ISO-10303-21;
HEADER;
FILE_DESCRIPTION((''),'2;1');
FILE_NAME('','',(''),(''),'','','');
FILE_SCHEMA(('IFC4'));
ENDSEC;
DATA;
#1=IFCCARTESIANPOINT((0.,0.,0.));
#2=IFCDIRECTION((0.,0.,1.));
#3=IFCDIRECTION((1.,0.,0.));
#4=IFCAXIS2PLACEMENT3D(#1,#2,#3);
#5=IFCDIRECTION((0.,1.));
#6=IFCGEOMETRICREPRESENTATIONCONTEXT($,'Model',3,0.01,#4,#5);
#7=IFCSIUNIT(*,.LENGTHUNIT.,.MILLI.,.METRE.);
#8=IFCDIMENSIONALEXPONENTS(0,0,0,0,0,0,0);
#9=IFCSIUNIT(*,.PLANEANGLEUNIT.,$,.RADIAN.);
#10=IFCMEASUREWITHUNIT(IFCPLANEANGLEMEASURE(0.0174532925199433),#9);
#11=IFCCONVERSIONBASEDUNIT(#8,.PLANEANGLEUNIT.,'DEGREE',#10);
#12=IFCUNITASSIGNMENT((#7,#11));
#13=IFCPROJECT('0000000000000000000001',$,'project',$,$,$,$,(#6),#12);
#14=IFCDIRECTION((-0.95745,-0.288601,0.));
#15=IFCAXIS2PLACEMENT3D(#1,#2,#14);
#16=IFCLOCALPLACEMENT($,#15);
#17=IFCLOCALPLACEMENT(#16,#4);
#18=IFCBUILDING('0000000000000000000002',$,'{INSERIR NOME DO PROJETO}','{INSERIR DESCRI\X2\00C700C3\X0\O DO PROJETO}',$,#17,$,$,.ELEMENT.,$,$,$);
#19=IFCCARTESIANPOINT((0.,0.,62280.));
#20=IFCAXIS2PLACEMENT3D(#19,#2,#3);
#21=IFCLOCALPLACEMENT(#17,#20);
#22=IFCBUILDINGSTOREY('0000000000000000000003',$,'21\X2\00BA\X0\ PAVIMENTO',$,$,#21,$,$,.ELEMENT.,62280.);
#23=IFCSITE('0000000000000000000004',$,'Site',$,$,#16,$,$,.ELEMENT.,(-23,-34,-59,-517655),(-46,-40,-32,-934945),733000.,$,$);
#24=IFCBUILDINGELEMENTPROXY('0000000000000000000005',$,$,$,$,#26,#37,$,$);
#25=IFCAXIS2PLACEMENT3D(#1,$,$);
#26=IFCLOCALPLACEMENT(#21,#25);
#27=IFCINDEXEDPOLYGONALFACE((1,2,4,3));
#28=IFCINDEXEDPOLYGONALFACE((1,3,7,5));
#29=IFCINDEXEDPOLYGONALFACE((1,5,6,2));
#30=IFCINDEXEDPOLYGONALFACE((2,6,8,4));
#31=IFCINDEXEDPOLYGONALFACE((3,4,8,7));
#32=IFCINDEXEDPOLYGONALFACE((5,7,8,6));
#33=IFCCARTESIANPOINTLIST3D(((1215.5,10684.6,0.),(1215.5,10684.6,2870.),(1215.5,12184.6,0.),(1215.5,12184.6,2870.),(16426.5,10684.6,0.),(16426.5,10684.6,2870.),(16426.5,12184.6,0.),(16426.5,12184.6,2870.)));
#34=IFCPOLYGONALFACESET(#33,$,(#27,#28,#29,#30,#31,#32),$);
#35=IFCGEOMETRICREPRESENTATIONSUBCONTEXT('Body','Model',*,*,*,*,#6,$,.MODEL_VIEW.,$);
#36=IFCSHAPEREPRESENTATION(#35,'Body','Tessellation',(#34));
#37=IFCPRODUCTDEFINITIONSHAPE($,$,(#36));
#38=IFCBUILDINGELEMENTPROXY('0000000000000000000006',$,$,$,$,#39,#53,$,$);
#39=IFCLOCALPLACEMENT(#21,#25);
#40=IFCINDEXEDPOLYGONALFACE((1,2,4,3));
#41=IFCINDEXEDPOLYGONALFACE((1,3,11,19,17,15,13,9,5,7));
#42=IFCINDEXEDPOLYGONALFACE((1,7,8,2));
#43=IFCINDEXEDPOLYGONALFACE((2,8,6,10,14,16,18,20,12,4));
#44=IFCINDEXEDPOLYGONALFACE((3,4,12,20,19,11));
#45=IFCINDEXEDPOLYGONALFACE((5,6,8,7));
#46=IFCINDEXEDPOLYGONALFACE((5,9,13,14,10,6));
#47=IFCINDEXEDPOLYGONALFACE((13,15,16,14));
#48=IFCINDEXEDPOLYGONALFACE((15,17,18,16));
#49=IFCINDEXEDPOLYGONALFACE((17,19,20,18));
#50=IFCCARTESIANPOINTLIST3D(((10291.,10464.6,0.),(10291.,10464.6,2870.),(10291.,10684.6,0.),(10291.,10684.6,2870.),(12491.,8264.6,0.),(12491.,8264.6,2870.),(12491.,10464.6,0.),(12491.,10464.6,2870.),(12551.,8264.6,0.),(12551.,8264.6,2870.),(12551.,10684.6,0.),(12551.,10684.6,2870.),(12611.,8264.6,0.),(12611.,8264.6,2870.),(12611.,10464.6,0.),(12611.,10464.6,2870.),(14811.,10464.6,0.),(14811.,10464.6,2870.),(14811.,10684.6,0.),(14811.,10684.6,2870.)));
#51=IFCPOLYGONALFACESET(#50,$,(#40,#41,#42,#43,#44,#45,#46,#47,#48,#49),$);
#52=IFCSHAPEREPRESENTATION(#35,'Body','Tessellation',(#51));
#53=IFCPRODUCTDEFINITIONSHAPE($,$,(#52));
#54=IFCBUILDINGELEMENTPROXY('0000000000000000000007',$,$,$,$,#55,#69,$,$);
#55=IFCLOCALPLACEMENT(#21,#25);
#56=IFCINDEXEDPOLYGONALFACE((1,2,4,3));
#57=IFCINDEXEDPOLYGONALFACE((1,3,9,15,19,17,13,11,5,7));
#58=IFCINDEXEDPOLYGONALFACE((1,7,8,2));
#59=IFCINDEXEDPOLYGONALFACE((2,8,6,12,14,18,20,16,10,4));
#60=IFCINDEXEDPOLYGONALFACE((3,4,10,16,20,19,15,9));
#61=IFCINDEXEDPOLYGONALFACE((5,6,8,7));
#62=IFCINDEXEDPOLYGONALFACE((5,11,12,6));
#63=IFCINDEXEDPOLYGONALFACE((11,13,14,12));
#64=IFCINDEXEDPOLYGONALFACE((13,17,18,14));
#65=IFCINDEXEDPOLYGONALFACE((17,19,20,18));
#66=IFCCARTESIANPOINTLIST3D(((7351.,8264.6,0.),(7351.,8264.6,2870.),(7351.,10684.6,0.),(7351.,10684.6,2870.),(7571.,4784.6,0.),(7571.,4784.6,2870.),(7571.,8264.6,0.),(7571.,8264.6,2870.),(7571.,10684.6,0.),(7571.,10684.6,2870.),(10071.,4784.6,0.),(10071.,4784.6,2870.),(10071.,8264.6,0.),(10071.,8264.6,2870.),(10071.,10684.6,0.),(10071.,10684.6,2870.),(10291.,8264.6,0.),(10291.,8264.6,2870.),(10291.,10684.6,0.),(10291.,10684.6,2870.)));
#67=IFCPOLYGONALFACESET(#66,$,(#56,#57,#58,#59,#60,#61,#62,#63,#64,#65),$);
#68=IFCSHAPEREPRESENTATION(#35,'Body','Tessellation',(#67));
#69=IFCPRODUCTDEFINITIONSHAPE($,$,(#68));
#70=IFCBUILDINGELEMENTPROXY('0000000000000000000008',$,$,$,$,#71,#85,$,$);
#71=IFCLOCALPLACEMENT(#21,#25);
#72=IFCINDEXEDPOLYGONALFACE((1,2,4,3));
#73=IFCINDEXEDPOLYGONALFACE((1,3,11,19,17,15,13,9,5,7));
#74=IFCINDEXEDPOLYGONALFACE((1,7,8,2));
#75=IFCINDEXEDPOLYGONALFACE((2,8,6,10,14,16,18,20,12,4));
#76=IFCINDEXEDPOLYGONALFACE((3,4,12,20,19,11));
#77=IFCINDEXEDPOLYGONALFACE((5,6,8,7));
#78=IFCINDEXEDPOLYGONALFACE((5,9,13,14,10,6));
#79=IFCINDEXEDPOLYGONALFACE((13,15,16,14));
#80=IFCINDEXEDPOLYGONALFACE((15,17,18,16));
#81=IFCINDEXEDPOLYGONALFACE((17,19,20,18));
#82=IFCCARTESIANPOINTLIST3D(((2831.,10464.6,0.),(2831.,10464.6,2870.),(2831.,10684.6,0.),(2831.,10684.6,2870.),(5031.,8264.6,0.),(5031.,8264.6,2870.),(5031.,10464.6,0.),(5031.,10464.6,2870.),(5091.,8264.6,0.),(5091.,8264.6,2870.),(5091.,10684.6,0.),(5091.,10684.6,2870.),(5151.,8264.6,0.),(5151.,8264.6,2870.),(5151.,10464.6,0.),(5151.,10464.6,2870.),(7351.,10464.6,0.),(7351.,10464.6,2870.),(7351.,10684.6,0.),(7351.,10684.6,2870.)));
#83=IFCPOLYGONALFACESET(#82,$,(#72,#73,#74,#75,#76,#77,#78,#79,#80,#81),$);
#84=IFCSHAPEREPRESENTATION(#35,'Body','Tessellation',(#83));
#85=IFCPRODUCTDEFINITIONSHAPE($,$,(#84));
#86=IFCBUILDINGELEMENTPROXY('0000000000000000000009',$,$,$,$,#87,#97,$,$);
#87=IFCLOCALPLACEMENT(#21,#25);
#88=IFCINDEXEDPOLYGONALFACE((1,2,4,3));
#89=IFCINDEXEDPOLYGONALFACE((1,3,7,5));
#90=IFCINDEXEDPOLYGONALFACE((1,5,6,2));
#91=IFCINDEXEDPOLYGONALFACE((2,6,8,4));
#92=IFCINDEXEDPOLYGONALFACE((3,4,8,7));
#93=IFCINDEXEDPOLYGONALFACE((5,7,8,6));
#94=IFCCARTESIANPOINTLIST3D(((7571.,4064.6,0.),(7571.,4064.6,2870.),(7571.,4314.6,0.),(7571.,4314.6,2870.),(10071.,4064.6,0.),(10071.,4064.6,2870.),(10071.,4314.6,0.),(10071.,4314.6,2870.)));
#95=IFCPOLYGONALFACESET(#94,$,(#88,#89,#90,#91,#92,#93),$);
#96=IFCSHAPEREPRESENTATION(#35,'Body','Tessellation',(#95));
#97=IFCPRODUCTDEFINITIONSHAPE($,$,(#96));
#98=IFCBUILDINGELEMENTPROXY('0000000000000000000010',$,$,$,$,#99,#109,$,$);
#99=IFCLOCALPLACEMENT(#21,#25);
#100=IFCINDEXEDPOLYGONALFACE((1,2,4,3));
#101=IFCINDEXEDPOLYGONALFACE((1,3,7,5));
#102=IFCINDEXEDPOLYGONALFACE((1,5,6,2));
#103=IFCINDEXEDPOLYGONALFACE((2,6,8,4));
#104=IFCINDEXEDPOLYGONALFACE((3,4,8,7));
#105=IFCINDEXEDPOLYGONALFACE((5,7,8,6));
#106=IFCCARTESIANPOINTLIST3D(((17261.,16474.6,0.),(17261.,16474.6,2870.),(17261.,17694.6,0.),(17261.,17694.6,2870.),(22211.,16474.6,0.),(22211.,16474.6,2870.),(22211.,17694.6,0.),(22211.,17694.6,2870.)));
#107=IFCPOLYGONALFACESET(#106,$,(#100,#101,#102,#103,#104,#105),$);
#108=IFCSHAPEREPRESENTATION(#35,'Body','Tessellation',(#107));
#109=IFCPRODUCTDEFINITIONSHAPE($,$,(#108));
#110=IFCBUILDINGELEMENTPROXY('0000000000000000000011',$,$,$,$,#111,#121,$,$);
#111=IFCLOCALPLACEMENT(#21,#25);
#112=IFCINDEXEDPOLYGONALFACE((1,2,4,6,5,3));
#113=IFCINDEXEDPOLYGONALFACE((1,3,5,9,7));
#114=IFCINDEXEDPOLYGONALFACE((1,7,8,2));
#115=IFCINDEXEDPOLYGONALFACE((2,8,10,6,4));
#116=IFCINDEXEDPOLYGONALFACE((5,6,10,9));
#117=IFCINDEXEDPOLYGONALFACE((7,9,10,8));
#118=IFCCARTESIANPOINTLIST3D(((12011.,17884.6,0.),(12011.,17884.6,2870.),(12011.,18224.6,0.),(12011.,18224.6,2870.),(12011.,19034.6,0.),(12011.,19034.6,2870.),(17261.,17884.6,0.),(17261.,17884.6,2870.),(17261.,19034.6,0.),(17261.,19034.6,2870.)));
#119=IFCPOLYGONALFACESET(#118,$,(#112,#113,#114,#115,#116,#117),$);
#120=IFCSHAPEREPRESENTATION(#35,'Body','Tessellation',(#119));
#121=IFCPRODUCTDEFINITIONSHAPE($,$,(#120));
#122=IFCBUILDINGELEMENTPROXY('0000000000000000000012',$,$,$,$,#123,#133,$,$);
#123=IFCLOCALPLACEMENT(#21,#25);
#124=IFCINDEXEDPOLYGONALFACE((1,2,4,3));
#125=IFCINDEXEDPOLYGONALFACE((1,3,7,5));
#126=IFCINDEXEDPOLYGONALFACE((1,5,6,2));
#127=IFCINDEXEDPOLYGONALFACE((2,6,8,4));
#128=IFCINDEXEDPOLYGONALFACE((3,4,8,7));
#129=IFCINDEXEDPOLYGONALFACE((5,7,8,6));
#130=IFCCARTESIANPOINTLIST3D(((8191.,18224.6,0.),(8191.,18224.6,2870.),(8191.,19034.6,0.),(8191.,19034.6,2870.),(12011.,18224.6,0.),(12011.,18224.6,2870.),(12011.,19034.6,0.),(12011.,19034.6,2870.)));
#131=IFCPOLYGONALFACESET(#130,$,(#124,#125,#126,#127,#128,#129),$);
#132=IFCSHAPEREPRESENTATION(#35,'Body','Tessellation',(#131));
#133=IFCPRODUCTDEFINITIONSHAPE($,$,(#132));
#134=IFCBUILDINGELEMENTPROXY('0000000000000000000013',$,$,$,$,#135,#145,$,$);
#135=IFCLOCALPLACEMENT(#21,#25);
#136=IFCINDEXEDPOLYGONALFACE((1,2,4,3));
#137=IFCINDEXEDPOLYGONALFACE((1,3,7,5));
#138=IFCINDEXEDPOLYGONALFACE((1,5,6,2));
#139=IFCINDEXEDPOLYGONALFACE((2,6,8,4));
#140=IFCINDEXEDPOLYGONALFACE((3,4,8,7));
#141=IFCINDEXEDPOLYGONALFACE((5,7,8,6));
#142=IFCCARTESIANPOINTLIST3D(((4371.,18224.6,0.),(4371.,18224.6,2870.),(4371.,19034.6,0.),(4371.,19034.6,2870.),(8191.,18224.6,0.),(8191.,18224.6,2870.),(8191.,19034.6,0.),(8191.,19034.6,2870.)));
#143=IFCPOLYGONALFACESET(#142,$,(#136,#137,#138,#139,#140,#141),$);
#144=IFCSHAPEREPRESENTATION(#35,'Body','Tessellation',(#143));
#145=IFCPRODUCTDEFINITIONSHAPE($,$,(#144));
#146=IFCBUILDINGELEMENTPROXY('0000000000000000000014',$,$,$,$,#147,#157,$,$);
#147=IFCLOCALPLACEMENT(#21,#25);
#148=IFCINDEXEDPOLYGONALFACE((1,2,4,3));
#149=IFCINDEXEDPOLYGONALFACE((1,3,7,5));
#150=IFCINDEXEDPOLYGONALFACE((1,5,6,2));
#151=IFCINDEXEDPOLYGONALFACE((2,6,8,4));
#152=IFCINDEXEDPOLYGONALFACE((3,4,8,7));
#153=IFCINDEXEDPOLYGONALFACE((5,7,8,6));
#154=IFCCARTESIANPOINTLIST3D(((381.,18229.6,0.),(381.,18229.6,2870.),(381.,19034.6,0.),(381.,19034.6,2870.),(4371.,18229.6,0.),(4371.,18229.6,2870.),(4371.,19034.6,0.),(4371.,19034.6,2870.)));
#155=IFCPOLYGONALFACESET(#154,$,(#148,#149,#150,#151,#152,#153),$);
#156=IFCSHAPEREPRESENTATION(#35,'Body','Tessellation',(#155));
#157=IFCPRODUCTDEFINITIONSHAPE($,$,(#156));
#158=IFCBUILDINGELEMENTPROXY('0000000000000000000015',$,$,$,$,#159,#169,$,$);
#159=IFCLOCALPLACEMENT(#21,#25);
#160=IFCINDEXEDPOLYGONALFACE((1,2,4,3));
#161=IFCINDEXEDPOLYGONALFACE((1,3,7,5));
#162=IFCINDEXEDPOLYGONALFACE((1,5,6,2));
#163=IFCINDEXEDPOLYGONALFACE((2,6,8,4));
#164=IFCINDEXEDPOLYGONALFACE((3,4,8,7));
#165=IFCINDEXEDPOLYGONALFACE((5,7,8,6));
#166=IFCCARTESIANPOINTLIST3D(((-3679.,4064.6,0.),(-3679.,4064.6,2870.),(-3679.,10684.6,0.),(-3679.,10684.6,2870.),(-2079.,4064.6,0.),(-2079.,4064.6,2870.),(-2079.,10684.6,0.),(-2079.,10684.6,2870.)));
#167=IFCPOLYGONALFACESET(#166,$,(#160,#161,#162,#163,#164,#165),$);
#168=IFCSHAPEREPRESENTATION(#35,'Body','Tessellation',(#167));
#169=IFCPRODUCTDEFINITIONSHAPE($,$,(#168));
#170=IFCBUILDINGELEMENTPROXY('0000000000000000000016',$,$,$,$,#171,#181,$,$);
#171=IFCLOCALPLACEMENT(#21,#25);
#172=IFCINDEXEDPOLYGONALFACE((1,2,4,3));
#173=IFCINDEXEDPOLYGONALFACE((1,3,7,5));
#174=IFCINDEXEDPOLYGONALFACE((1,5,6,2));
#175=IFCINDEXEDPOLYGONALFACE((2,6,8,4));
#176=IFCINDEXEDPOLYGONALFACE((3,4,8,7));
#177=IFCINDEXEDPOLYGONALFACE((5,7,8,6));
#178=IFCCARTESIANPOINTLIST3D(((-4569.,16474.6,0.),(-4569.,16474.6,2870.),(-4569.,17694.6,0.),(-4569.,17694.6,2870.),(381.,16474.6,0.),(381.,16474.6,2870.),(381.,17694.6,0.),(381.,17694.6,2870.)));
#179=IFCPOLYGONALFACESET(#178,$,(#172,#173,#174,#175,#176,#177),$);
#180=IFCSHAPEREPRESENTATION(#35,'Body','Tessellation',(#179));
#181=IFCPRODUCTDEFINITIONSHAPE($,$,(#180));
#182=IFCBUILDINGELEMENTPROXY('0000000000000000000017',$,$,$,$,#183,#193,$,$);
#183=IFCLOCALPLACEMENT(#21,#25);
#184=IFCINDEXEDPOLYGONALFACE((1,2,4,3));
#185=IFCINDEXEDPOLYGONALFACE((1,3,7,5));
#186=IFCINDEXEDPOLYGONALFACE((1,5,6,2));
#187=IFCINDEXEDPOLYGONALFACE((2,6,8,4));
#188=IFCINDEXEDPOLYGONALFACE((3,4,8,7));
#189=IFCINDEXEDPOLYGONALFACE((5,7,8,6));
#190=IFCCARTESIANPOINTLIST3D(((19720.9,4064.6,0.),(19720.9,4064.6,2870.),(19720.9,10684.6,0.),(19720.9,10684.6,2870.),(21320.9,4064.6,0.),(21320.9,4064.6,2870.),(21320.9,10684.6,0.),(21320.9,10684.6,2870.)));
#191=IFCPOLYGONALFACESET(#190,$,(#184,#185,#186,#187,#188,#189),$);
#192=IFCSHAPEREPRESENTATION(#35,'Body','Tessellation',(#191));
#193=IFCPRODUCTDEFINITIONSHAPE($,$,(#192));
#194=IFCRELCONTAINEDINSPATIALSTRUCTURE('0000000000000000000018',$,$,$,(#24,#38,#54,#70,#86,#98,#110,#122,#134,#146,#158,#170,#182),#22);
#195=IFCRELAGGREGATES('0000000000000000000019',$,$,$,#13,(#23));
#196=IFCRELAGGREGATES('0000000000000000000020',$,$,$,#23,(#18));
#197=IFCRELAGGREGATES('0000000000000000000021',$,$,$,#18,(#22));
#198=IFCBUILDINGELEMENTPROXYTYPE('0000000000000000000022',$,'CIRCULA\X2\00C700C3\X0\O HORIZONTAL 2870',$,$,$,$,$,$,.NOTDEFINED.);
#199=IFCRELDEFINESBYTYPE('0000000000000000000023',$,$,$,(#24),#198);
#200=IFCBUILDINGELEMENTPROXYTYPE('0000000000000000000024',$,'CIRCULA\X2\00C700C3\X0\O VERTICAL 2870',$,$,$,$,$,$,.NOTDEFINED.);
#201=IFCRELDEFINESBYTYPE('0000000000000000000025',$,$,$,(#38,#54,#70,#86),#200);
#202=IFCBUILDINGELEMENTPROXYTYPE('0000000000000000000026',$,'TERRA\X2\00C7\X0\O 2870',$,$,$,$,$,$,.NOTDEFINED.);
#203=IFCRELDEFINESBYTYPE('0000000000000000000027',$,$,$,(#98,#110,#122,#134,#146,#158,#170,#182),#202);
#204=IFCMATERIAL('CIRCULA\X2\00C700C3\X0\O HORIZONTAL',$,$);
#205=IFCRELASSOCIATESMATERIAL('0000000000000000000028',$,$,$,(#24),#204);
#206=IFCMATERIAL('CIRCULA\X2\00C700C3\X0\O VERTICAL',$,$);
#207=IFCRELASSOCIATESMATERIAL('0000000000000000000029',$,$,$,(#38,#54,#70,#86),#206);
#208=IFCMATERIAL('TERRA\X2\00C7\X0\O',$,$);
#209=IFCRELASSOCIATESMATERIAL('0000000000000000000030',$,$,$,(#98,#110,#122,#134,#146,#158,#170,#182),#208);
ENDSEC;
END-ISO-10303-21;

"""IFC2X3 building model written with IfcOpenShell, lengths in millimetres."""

from ifc_helpers import new_model, entity, si_unit, converted_unit, direction, frame, origin_with_axes, place, context, subcontext, project, spatial, polyline, outline, extrude, material, type_object, element, save


model = new_model("IFC2X3")

# Units and contexts
model_context = context("Model", 3, precision=0.01, world=origin_with_axes(), true_north=direction((0.0, 1.0)))
body_context = subcontext(model_context, "Body", "Model", "MODEL_VIEW")
ifc_project = project(units=[si_unit("LENGTHUNIT", "METRE", prefix="MILLI"), converted_unit("PLANEANGLEUNIT", "DEGREE", entity("IfcPlaneAngleMeasure", 0.0174532925199433), si_unit("PLANEANGLEUNIT", "RADIAN"), dimensions=[0, 0, 0, 0, 0, 0, 0])], contexts=[model_context])

# Site, building, storey
site_placement = place(None, frame((0.0, 0.0, 0.0), z_axis=(0.0, 0.0, 1.0), x_axis=(-0.95745, -0.288601, 0.0)))
site = spatial("IfcSite", under=ifc_project, at=site_placement, Name="Site", CompositionType="ELEMENT", RefLatitude=(-23, -34, -59, -517655), RefLongitude=(-46, -40, -32, -934945), RefElevation=733000.0)
building_placement = place(site_placement, origin_with_axes())
building = spatial("IfcBuilding", under=site, at=building_placement, Name="{INSERIR NOME DO PROJETO}", Description="{INSERIR DESCRIÇÃO DO PROJETO}", CompositionType="ELEMENT")
storey_placement = place(building_placement, frame((0.0, 0.0, 62280.0), z_axis=(0.0, 0.0, 1.0), x_axis=(1.0, 0.0, 0.0)))
storey = spatial("IfcBuildingStorey", under=building, at=storey_placement, Name="21º PAVIMENTO", CompositionType="ELEMENT", Elevation=62280.0)

# Building element proxies
ifc_material_1 = material(Name="CIRCULAÇÃO HORIZONTAL")
building_element_proxy_type_1 = type_object("IfcBuildingElementProxyType", Name="CIRCULAÇÃO HORIZONTAL 2870", PredefinedType="NOTDEFINED")
proxy_1_placement = place(storey_placement, frame((1215.5, 10684.6, 0.0), z_axis=(0.0, 0.0, 1.0), x_axis=(1.0, 0.0, 0.0)))
element("IfcBuildingElementProxy", 1, at=proxy_1_placement, inside=storey, type_object=building_element_proxy_type_1, material=ifc_material_1, context=body_context, shape_type="SweptSolid", body=[
    extrude(outline(polyline([(0.0, 0.0), (15211.0, 0.0), (15211.0, 1500.0), (0.0, 1500.0), (0.0, 0.0)])), origin_with_axes(), (0.0, 0.0, 1.0), 2870.0),
])
ifc_material_2 = material(Name="CIRCULAÇÃO VERTICAL")
building_element_proxy_type_2 = type_object("IfcBuildingElementProxyType", Name="CIRCULAÇÃO VERTICAL 2870", PredefinedType="NOTDEFINED")
proxy_2_placement = place(storey_placement, frame((10291.0, 10684.6, 0.0), z_axis=(0.0, 0.0, 1.0), x_axis=(1.0, 0.0, 0.0)))
element("IfcBuildingElementProxy", 2, at=proxy_2_placement, inside=storey, type_object=building_element_proxy_type_2, material=ifc_material_2, context=body_context, shape_type="SweptSolid", body=[
    extrude(outline(polyline([(0.0, 0.0), (0.0, -220.0), (2200.0, -220.0), (2200.0, -2420.0), (2260.0, -2420.0), (2320.0, -2420.0), (2320.0, -220.0), (4520.0, -220.0), (4520.0, 0.0), (2260.0, 0.0), (0.0, 0.0)])), origin_with_axes(), (0.0, 0.0, 1.0), 2870.0),
])
proxy_3_placement = place(storey_placement, frame((7351.0, 10684.6, 0.0), z_axis=(0.0, 0.0, 1.0), x_axis=(1.0, 0.0, 0.0)))
element("IfcBuildingElementProxy", 3, at=proxy_3_placement, inside=storey, type_object=building_element_proxy_type_2, material=ifc_material_2, context=body_context, shape_type="SweptSolid", body=[
    extrude(outline(polyline([(0.0, 0.0), (0.0, -2420.0), (220.0, -2420.0), (220.0, -5900.0), (2720.0, -5900.0), (2720.0, -2420.0), (2940.0, -2420.0), (2940.0, 0.0), (2720.0, 0.0), (220.0, 0.0), (0.0, 0.0)])), origin_with_axes(), (0.0, 0.0, 1.0), 2870.0),
])
proxy_4_placement = place(storey_placement, frame((5091.0, 10684.6, 0.0), z_axis=(0.0, 0.0, 1.0), x_axis=(1.0, 0.0, 0.0)))
element("IfcBuildingElementProxy", 4, at=proxy_4_placement, inside=storey, type_object=building_element_proxy_type_2, material=ifc_material_2, context=body_context, shape_type="SweptSolid", body=[
    extrude(outline(polyline([(0.0, 0.0), (-2260.0, 0.0), (-2260.0, -220.0), (-60.0, -220.0), (-60.0, -2420.0), (0.0, -2420.0), (60.0, -2420.0), (60.0, -220.0), (2260.0, -220.0), (2260.0, 0.0), (0.0, 0.0)])), origin_with_axes(), (0.0, 0.0, 1.0), 2870.0),
])
proxy_5_placement = place(storey_placement, frame((7571.0, 4064.6, 0.0), z_axis=(0.0, 0.0, 1.0), x_axis=(1.0, 0.0, 0.0)))
element("IfcBuildingElementProxy", 5, at=proxy_5_placement, inside=storey, type_object=building_element_proxy_type_2, material=ifc_material_2, context=body_context, shape_type="SweptSolid", body=[
    extrude(outline(polyline([(0.0, 0.0), (2500.0, 0.0), (2500.0, 250.0), (0.0, 250.0), (0.0, 0.0)])), origin_with_axes(), (0.0, 0.0, 1.0), 2870.0),
])
ifc_material_3 = material(Name="TERRAÇO")
building_element_proxy_type_3 = type_object("IfcBuildingElementProxyType", Name="TERRAÇO 2870", PredefinedType="NOTDEFINED")
proxy_6_placement = place(storey_placement, frame((17261.0, 16474.6, 0.0), z_axis=(0.0, 0.0, 1.0), x_axis=(1.0, 0.0, 0.0)))
element("IfcBuildingElementProxy", 6, at=proxy_6_placement, inside=storey, type_object=building_element_proxy_type_3, material=ifc_material_3, context=body_context, shape_type="SweptSolid", body=[
    extrude(outline(polyline([(0.0, 0.0), (4950.0, 0.0), (4950.0, 1220.0), (0.0, 1220.0), (0.0, 0.0)])), origin_with_axes(), (0.0, 0.0, 1.0), 2870.0),
])
proxy_7_placement = place(storey_placement, frame((12011.0, 19034.6, 0.0), z_axis=(0.0, 0.0, 1.0), x_axis=(1.0, 0.0, 0.0)))
element("IfcBuildingElementProxy", 7, at=proxy_7_placement, inside=storey, type_object=building_element_proxy_type_3, material=ifc_material_3, context=body_context, shape_type="SweptSolid", body=[
    extrude(outline(polyline([(0.0, 0.0), (0.0, -810.0), (0.0, -1150.0), (5250.0, -1150.0), (5250.0, 0.0), (0.0, 0.0)])), origin_with_axes(), (0.0, 0.0, 1.0), 2870.0),
])
for number, where, z_axis, x_axis in (
    (8, (8191.0, 18224.6, 0.0), (0.0, 0.0, 1.0), (1.0, 0.0, 0.0)),
    (9, (4371.0, 18224.6, 0.0), (0.0, 0.0, 1.0), (1.0, 0.0, 0.0)),
):
    element("IfcBuildingElementProxy", number, at=place(storey_placement, frame(where, z_axis=z_axis, x_axis=x_axis)), inside=storey, type_object=building_element_proxy_type_3, material=ifc_material_3, context=body_context, shape_type="SweptSolid", body=[
        extrude(outline(polyline([(0.0, 0.0), (3820.0, 0.0), (3820.0, 810.0), (0.0, 810.0), (0.0, 0.0)])), origin_with_axes(), (0.0, 0.0, 1.0), 2870.0),
    ])
proxy_8_placement = place(storey_placement, frame((381.0, 19034.6, 0.0), z_axis=(0.0, 0.0, 1.0), x_axis=(1.0, 0.0, 0.0)))
element("IfcBuildingElementProxy", 10, at=proxy_8_placement, inside=storey, type_object=building_element_proxy_type_3, material=ifc_material_3, context=body_context, shape_type="SweptSolid", body=[
    extrude(outline(polyline([(0.0, 0.0), (0.0, -805.0), (3990.0, -805.0), (3990.0, 0.0), (0.0, 0.0)])), origin_with_axes(), (0.0, 0.0, 1.0), 2870.0),
])
proxy_9_placement = place(storey_placement, frame((-3679.0, 4064.6, 0.0), z_axis=(0.0, 0.0, 1.0), x_axis=(1.0, 0.0, 0.0)))
element("IfcBuildingElementProxy", 11, at=proxy_9_placement, inside=storey, type_object=building_element_proxy_type_3, material=ifc_material_3, context=body_context, shape_type="SweptSolid", body=[
    extrude(outline(polyline([(0.0, 0.0), (1600.0, 0.0), (1600.0, 6620.0), (0.0, 6620.0), (0.0, 0.0)])), origin_with_axes(), (0.0, 0.0, 1.0), 2870.0),
])
proxy_10_placement = place(storey_placement, frame((381.0, 17694.6, 0.0), z_axis=(0.0, 0.0, 1.0), x_axis=(1.0, 0.0, 0.0)))
element("IfcBuildingElementProxy", 12, at=proxy_10_placement, inside=storey, type_object=building_element_proxy_type_3, material=ifc_material_3, context=body_context, shape_type="SweptSolid", body=[
    extrude(outline(polyline([(0.0, 0.0), (-4950.0, 0.0), (-4950.0, -1220.0), (0.0, -1220.0), (0.0, 0.0)])), origin_with_axes(), (0.0, 0.0, 1.0), 2870.0),
])
proxy_11_placement = place(storey_placement, frame((21320.9, 4064.6, 0.0), z_axis=(0.0, 0.0, 1.0), x_axis=(1.0, 0.0, 0.0)))
element("IfcBuildingElementProxy", 13, at=proxy_11_placement, inside=storey, type_object=building_element_proxy_type_3, material=ifc_material_3, context=body_context, shape_type="SweptSolid", body=[
    extrude(outline(polyline([(0.0, 0.0), (0.0, 6620.0), (-1600.0, 6620.0), (-1600.0, 0.0), (0.0, 0.0)])), origin_with_axes(), (0.0, 0.0, 1.0), 2870.0),
])

save(model, "model.ifc")
